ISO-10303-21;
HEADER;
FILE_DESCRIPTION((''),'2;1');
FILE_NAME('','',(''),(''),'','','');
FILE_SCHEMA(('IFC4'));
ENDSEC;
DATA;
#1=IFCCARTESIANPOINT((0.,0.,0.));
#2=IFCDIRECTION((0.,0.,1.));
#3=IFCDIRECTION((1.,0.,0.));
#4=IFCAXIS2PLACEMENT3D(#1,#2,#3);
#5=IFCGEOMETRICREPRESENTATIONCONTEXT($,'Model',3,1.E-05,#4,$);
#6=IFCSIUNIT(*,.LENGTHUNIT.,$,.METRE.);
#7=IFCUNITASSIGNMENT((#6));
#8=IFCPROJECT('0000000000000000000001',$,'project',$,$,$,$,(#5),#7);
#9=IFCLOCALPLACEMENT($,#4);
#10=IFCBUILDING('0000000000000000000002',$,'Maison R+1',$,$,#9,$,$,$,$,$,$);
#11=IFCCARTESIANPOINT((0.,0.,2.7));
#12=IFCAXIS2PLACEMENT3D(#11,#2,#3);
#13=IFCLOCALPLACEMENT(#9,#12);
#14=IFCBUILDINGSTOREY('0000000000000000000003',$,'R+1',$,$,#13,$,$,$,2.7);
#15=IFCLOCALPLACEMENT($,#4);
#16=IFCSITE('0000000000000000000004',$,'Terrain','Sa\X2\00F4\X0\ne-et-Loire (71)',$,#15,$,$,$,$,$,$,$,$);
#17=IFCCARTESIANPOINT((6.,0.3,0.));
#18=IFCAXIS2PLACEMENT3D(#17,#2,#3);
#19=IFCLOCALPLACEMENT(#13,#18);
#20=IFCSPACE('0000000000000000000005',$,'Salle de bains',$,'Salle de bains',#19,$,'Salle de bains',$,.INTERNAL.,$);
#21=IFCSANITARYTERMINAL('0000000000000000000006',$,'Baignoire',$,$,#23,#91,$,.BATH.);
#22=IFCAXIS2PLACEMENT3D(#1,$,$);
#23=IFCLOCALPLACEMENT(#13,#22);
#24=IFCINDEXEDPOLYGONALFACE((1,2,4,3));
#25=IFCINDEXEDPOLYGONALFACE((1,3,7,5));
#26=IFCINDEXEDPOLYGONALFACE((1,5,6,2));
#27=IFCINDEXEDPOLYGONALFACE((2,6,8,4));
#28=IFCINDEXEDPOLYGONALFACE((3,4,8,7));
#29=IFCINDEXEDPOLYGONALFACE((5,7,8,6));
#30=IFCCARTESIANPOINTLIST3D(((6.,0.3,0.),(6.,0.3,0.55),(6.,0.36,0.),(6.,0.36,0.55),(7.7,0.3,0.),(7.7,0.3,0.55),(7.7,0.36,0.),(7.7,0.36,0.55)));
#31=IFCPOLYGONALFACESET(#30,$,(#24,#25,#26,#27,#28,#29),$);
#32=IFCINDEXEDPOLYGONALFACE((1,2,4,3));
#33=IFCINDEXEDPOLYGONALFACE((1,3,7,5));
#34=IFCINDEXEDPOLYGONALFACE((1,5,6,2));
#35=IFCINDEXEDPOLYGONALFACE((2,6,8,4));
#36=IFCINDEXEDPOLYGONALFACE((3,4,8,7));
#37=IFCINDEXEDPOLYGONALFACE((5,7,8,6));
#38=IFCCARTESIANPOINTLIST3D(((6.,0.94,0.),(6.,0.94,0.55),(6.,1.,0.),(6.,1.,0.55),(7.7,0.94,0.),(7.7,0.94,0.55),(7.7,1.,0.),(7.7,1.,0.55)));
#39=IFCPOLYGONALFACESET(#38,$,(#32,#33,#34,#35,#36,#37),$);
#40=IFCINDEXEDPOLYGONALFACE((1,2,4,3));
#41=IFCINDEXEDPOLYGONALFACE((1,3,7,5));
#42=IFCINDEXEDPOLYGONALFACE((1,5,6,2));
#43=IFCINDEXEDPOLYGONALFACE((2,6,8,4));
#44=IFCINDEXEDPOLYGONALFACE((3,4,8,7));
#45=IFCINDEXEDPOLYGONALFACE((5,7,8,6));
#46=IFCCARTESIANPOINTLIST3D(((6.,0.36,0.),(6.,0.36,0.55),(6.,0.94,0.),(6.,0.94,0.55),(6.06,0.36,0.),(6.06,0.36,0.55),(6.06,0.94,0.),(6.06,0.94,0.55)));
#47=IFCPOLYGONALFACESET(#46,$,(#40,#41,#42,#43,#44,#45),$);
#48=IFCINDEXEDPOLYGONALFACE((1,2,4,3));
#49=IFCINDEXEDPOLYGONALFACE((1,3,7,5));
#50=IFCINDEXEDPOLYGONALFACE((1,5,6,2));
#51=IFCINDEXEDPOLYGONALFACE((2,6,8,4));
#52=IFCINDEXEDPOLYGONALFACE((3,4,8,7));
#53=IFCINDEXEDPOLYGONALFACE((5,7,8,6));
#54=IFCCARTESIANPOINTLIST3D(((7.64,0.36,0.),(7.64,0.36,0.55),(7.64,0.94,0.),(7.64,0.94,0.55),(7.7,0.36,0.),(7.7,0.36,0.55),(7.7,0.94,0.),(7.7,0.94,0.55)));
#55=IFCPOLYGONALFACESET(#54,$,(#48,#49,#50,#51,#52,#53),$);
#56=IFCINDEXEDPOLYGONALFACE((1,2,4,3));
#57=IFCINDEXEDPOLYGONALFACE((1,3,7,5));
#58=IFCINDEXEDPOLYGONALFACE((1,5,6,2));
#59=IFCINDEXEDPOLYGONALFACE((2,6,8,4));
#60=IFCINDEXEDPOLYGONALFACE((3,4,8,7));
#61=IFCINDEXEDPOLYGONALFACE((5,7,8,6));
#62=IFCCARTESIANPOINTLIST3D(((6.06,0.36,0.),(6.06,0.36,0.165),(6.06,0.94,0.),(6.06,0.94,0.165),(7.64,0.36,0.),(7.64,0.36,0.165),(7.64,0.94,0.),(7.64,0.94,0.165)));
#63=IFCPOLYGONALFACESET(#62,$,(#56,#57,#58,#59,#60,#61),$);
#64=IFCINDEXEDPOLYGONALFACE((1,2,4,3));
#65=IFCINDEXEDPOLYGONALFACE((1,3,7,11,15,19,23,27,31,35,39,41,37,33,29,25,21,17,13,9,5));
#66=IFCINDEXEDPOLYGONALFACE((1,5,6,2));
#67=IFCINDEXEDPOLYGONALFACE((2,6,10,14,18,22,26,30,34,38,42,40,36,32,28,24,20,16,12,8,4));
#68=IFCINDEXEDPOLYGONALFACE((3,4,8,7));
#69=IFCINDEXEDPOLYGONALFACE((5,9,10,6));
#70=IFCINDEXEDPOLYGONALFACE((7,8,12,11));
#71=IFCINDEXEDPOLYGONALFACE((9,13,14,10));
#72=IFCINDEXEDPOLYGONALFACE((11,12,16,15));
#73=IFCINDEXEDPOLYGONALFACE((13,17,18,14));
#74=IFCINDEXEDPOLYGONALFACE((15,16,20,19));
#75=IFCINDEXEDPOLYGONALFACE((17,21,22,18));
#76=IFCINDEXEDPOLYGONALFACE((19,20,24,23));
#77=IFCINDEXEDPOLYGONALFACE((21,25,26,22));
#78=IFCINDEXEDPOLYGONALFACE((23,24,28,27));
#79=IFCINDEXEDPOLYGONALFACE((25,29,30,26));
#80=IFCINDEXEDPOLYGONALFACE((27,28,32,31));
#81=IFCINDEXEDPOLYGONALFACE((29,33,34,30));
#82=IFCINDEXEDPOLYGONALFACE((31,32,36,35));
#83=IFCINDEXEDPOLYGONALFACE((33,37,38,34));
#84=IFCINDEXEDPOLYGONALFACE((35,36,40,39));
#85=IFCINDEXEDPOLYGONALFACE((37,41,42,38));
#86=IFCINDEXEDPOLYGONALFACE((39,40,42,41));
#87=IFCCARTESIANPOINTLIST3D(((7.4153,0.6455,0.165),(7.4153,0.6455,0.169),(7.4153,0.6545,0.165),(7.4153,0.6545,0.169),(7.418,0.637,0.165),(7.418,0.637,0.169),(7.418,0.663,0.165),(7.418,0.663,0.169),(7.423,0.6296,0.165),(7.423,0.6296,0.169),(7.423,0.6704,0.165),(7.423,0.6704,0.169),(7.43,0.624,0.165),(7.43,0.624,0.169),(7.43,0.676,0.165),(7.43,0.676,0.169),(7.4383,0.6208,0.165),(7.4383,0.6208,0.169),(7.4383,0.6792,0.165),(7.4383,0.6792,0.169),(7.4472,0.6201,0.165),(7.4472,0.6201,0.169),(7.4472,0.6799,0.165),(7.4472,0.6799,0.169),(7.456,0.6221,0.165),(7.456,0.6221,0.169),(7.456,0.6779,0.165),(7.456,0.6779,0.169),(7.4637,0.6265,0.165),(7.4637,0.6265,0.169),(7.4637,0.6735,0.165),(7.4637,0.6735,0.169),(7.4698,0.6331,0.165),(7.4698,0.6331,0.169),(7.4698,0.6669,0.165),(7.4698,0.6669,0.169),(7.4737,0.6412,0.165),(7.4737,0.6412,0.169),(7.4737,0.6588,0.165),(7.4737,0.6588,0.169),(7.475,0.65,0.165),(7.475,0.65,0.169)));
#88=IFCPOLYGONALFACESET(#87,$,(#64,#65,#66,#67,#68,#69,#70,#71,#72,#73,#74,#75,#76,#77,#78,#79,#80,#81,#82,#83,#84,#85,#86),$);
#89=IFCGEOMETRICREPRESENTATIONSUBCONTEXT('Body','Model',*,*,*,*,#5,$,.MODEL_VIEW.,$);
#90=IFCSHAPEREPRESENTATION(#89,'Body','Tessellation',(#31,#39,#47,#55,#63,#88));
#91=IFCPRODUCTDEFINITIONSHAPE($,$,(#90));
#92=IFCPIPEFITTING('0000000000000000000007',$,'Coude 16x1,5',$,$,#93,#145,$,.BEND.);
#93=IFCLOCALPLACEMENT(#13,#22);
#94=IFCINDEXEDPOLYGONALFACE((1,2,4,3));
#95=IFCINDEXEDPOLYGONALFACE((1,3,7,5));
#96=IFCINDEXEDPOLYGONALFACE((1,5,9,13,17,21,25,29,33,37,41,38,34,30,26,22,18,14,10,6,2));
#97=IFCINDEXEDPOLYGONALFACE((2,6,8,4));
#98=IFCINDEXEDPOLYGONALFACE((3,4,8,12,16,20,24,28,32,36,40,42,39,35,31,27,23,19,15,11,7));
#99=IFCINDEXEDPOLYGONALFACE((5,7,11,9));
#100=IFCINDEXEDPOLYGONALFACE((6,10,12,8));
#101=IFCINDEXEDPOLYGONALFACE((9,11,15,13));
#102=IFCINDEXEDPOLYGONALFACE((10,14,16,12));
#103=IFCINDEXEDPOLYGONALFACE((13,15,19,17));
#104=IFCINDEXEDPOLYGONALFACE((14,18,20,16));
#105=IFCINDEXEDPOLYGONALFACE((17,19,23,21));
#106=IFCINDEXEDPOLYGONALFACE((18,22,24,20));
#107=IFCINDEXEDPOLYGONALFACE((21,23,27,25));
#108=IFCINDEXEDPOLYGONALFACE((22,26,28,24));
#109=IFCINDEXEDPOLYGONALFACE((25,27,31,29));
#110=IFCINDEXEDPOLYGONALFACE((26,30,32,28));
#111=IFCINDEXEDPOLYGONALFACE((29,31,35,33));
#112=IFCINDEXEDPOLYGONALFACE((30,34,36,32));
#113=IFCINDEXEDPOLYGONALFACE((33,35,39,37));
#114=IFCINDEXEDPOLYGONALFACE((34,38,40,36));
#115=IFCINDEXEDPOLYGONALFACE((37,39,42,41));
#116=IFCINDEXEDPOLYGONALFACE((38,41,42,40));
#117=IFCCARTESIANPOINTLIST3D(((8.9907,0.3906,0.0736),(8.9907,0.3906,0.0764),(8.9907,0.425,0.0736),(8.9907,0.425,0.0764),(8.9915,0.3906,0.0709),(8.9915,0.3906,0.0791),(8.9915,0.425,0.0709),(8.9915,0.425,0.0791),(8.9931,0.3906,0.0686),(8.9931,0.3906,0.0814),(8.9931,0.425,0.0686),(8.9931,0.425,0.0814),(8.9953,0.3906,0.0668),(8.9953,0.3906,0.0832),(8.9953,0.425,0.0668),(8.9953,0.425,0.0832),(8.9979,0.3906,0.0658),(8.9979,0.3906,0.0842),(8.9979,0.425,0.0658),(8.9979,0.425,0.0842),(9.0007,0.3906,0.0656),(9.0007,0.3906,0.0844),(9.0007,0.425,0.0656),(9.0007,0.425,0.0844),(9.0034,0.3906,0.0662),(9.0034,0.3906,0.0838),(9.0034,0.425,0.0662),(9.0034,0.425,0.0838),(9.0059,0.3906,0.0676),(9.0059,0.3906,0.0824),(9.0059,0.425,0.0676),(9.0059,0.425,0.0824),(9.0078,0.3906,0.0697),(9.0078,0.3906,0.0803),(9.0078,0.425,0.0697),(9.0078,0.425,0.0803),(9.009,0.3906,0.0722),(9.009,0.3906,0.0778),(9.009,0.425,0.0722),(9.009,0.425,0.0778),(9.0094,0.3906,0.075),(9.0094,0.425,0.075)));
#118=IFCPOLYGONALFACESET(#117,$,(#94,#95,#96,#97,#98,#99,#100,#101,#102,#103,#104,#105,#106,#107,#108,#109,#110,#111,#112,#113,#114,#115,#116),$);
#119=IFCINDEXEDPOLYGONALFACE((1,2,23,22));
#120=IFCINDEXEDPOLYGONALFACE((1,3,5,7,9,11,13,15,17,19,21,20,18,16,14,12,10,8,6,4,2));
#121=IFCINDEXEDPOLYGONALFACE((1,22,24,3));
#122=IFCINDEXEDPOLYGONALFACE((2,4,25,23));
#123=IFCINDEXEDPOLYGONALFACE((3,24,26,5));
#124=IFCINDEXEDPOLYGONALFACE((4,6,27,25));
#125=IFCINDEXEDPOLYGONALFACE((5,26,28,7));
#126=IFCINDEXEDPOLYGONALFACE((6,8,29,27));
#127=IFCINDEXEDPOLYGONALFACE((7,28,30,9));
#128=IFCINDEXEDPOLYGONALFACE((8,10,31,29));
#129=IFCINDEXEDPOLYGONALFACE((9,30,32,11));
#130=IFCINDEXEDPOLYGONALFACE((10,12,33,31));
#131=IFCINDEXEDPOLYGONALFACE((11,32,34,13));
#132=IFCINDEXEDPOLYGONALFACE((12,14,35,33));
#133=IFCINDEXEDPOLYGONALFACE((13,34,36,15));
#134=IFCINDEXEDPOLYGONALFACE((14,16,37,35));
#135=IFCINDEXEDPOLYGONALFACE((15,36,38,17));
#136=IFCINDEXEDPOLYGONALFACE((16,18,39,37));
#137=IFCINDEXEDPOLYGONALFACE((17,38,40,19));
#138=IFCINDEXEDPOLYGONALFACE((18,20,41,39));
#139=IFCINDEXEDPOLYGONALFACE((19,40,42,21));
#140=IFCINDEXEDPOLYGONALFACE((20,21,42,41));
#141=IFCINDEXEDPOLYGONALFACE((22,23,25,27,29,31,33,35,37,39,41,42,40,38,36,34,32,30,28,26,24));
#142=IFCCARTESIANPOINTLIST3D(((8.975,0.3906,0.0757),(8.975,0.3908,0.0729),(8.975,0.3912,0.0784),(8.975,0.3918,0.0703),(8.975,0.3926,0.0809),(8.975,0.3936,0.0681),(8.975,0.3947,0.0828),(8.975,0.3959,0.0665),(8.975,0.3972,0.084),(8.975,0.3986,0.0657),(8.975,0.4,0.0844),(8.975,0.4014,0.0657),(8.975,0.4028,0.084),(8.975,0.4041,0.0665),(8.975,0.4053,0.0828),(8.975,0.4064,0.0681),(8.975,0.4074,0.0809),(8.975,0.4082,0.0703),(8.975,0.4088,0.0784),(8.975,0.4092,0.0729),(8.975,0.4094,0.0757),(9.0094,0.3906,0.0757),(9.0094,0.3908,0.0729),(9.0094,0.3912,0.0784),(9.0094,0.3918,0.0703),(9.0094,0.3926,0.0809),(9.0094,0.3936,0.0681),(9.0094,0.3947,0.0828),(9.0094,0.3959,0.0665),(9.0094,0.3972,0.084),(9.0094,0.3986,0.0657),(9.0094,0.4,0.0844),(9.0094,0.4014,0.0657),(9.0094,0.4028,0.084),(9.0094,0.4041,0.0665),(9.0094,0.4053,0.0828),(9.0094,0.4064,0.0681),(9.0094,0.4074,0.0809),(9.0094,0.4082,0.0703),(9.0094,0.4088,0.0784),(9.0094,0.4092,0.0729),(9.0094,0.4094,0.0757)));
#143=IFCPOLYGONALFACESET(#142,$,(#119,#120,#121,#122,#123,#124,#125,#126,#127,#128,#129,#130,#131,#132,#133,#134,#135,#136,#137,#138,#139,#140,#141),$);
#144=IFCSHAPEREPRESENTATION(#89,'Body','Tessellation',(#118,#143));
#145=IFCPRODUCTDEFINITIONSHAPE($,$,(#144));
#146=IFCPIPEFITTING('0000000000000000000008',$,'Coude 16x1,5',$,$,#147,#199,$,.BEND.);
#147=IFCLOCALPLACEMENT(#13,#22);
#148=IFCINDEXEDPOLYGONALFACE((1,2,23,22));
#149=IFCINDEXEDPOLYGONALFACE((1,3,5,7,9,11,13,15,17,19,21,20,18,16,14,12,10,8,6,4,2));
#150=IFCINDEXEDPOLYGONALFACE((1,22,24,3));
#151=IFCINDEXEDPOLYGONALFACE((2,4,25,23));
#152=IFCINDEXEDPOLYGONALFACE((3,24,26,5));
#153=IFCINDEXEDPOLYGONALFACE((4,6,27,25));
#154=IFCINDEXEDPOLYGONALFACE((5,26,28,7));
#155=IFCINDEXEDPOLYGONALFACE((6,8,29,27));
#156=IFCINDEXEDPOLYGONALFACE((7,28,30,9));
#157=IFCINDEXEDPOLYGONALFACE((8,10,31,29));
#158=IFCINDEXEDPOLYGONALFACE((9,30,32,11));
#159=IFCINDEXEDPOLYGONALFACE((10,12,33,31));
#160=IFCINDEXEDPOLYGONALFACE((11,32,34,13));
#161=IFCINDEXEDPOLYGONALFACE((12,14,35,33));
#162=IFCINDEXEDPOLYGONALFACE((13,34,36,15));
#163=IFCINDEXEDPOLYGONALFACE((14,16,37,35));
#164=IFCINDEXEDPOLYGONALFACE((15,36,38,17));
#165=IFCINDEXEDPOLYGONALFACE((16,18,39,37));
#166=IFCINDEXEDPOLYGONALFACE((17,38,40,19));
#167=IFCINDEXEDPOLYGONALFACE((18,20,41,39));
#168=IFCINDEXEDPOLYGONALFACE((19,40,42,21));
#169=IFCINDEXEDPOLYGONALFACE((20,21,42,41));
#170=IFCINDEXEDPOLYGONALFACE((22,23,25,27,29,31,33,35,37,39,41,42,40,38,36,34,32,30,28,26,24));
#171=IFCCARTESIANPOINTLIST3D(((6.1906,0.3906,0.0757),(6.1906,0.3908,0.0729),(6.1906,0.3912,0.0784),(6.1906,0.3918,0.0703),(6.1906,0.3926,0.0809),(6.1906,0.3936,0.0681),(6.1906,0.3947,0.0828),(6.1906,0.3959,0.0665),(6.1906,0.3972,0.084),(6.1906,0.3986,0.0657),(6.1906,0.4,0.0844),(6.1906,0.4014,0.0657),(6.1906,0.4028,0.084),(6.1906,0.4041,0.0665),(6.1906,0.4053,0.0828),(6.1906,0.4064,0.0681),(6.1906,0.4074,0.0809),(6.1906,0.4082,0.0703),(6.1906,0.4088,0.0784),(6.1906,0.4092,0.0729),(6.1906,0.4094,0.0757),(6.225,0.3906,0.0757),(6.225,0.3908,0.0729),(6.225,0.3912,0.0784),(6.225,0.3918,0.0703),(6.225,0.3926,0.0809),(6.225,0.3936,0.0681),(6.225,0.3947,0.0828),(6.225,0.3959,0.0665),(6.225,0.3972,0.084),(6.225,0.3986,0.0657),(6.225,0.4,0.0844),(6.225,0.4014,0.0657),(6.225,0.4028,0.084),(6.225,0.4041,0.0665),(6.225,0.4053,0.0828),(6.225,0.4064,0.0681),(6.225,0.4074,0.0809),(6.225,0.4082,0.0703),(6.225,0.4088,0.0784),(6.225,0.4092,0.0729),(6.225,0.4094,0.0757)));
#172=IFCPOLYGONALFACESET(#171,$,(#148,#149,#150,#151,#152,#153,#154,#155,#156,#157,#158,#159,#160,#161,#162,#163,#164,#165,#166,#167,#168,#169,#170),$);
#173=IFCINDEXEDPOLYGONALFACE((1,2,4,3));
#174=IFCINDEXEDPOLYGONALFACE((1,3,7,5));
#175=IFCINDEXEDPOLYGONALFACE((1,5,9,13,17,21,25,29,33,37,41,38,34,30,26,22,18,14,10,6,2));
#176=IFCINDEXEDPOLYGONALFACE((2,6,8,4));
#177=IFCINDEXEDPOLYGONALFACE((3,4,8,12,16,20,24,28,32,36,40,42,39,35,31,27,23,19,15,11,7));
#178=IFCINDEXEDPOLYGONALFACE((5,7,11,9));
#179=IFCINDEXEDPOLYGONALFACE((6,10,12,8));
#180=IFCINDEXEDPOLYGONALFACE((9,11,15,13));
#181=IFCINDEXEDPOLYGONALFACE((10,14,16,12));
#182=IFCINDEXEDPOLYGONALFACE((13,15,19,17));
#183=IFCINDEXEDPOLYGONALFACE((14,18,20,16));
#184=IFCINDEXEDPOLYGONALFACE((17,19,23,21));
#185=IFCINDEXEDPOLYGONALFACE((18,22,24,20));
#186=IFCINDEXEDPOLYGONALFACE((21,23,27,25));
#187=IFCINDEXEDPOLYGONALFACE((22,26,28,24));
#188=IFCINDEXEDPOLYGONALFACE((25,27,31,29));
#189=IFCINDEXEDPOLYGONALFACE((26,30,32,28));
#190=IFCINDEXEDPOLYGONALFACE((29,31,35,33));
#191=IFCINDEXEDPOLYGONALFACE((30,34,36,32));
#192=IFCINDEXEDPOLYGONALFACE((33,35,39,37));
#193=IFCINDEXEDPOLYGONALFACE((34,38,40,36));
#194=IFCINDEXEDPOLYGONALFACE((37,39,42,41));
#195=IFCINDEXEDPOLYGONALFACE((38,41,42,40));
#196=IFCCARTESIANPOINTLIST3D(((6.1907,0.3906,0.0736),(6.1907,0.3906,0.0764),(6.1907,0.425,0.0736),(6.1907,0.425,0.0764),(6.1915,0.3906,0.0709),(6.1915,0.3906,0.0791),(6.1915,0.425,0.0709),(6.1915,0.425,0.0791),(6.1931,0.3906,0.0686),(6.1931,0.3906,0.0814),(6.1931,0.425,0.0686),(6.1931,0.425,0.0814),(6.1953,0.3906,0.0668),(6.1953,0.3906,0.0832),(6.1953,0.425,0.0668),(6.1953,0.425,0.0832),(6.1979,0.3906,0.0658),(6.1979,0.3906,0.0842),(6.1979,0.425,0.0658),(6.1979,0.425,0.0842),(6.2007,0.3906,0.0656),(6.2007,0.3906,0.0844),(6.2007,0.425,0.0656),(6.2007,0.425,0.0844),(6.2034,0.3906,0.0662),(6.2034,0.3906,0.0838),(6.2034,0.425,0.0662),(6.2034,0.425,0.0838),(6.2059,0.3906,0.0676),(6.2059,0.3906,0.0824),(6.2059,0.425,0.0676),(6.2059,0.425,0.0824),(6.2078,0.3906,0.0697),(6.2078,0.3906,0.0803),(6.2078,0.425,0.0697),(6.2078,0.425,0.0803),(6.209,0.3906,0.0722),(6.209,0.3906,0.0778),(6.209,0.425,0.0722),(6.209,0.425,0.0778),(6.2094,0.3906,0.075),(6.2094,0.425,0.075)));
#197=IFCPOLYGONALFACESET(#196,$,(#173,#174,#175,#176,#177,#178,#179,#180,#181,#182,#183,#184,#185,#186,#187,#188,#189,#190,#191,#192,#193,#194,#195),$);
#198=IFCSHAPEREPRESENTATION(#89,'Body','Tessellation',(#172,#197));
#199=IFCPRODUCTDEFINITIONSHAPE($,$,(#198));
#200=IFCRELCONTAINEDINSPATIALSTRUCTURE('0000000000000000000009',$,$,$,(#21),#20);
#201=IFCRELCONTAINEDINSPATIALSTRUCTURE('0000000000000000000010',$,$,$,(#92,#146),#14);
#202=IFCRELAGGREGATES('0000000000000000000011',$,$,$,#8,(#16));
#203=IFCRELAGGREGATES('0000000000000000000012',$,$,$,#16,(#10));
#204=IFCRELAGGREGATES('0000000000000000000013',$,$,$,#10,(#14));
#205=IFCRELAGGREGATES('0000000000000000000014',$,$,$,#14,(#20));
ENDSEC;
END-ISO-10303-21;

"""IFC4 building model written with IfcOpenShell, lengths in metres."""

from ifc_helpers import new_model, si_unit, frame, frame_2d, origin_with_axes, place, context, subcontext, project, spatial, rectangle, circle, extrude, element, save


model = new_model("IFC4")

# Units and contexts
model_context = context("Model", 3, precision=1e-05, world=origin_with_axes())
body_context = subcontext(model_context, "Body", "Model", "MODEL_VIEW")
ifc_project = project(units=[si_unit("LENGTHUNIT", "METRE")], contexts=[model_context])

# Site, building, storey
site_placement = place(None, origin_with_axes())
site = spatial("IfcSite", under=ifc_project, at=site_placement, Name="Terrain", Description="Saône-et-Loire (71)")
building_placement = place(None, origin_with_axes())
building = spatial("IfcBuilding", under=site, at=building_placement, Name="Maison R+1")
storey_placement = place(building_placement, frame((0.0, 0.0, 2.7), z_axis=(0.0, 0.0, 1.0), x_axis=(1.0, 0.0, 0.0)))
storey = spatial("IfcBuildingStorey", under=building, at=storey_placement, Name="R+1", Elevation=2.7)

# Shared definitions
space_placement = place(storey_placement, frame((6.0, 0.3, 0.0), z_axis=(0.0, 0.0, 1.0), x_axis=(1.0, 0.0, 0.0)))
space = spatial("IfcSpace", under=storey, at=space_placement, Name="Salle de bains", ObjectType="Salle de bains", LongName="Salle de bains", PredefinedType="INTERNAL")

# Sanitary terminal
sanitary_terminal_placement = place(space_placement, origin_with_axes())
element("IfcSanitaryTerminal", 1, at=sanitary_terminal_placement, inside=space, Name="Baignoire", PredefinedType="BATH", context=body_context, shape_type="SweptSolid", body=[
    extrude(rectangle(XDim=1.7, YDim=0.06, at=frame_2d((0.85, 0.03))), origin_with_axes(), (0.0, 0.0, 1.0), 0.55),
    extrude(rectangle(XDim=1.7, YDim=0.06, at=frame_2d((0.85, 0.03))), frame((0.0, 0.64, 0.0), z_axis=(0.0, 0.0, 1.0), x_axis=(1.0, 0.0, 0.0)), (0.0, 0.0, 1.0), 0.55),
    extrude(rectangle(XDim=0.06, YDim=0.58, at=frame_2d((0.03, 0.29))), frame((0.0, 0.06, 0.0), z_axis=(0.0, 0.0, 1.0), x_axis=(1.0, 0.0, 0.0)), (0.0, 0.0, 1.0), 0.55),
    extrude(rectangle(XDim=0.06, YDim=0.58, at=frame_2d((0.03, 0.29))), frame((1.64, 0.06, 0.0), z_axis=(0.0, 0.0, 1.0), x_axis=(1.0, 0.0, 0.0)), (0.0, 0.0, 1.0), 0.55),
    extrude(rectangle(XDim=1.58, YDim=0.58, at=frame_2d((0.79, 0.29))), frame((0.06, 0.06, 0.0), z_axis=(0.0, 0.0, 1.0), x_axis=(1.0, 0.0, 0.0)), (0.0, 0.0, 1.0), 0.165),
    extrude(circle(Radius=0.03), frame((1.445, 0.35, 0.165), z_axis=(0.0, 0.0, 1.0), x_axis=(1.0, 0.0, 0.0)), (0.0, 0.0, 1.0), 0.004),
])

# Pipe fittings
pipe_fitting_1_placement = place(storey_placement, frame((9.0, 0.4, 0.075), z_axis=(0.0, 0.0, 1.0), x_axis=(1.0, 0.0, 0.0)))
element("IfcPipeFitting", 2, at=pipe_fitting_1_placement, inside=storey, Name="Coude 16x1,5", PredefinedType="BEND", context=body_context, shape_type="SweptSolid", body=[
    extrude(circle(Radius=0.0094), frame((0.0, -0.0094, 0.0), z_axis=(0.0, 1.0, 0.0), x_axis=(1.0, 0.0, 0.0)), (0.0, 0.0, 1.0), 0.0344),
    extrude(circle(Radius=0.0094), frame((0.0094, 0.0, 0.0), z_axis=(-1.0, 0.0, 0.0), x_axis=(0.0, 0.0, 1.0)), (0.0, 0.0, 1.0), 0.0344),
])
pipe_fitting_2_placement = place(storey_placement, frame((6.2, 0.4, 0.075), z_axis=(0.0, 0.0, 1.0), x_axis=(1.0, 0.0, 0.0)))
element("IfcPipeFitting", 3, at=pipe_fitting_2_placement, inside=storey, Name="Coude 16x1,5", PredefinedType="BEND", context=body_context, shape_type="SweptSolid", body=[
    extrude(circle(Radius=0.0094), frame((-0.0094, 0.0, 0.0), z_axis=(1.0, 0.0, 0.0), x_axis=(0.0, 0.0, 1.0)), (0.0, 0.0, 1.0), 0.0344),
    extrude(circle(Radius=0.0094), frame((0.0, -0.0094, 0.0), z_axis=(0.0, 1.0, 0.0), x_axis=(1.0, 0.0, 0.0)), (0.0, 0.0, 1.0), 0.0344),
])

save(model, "model.ifc")
